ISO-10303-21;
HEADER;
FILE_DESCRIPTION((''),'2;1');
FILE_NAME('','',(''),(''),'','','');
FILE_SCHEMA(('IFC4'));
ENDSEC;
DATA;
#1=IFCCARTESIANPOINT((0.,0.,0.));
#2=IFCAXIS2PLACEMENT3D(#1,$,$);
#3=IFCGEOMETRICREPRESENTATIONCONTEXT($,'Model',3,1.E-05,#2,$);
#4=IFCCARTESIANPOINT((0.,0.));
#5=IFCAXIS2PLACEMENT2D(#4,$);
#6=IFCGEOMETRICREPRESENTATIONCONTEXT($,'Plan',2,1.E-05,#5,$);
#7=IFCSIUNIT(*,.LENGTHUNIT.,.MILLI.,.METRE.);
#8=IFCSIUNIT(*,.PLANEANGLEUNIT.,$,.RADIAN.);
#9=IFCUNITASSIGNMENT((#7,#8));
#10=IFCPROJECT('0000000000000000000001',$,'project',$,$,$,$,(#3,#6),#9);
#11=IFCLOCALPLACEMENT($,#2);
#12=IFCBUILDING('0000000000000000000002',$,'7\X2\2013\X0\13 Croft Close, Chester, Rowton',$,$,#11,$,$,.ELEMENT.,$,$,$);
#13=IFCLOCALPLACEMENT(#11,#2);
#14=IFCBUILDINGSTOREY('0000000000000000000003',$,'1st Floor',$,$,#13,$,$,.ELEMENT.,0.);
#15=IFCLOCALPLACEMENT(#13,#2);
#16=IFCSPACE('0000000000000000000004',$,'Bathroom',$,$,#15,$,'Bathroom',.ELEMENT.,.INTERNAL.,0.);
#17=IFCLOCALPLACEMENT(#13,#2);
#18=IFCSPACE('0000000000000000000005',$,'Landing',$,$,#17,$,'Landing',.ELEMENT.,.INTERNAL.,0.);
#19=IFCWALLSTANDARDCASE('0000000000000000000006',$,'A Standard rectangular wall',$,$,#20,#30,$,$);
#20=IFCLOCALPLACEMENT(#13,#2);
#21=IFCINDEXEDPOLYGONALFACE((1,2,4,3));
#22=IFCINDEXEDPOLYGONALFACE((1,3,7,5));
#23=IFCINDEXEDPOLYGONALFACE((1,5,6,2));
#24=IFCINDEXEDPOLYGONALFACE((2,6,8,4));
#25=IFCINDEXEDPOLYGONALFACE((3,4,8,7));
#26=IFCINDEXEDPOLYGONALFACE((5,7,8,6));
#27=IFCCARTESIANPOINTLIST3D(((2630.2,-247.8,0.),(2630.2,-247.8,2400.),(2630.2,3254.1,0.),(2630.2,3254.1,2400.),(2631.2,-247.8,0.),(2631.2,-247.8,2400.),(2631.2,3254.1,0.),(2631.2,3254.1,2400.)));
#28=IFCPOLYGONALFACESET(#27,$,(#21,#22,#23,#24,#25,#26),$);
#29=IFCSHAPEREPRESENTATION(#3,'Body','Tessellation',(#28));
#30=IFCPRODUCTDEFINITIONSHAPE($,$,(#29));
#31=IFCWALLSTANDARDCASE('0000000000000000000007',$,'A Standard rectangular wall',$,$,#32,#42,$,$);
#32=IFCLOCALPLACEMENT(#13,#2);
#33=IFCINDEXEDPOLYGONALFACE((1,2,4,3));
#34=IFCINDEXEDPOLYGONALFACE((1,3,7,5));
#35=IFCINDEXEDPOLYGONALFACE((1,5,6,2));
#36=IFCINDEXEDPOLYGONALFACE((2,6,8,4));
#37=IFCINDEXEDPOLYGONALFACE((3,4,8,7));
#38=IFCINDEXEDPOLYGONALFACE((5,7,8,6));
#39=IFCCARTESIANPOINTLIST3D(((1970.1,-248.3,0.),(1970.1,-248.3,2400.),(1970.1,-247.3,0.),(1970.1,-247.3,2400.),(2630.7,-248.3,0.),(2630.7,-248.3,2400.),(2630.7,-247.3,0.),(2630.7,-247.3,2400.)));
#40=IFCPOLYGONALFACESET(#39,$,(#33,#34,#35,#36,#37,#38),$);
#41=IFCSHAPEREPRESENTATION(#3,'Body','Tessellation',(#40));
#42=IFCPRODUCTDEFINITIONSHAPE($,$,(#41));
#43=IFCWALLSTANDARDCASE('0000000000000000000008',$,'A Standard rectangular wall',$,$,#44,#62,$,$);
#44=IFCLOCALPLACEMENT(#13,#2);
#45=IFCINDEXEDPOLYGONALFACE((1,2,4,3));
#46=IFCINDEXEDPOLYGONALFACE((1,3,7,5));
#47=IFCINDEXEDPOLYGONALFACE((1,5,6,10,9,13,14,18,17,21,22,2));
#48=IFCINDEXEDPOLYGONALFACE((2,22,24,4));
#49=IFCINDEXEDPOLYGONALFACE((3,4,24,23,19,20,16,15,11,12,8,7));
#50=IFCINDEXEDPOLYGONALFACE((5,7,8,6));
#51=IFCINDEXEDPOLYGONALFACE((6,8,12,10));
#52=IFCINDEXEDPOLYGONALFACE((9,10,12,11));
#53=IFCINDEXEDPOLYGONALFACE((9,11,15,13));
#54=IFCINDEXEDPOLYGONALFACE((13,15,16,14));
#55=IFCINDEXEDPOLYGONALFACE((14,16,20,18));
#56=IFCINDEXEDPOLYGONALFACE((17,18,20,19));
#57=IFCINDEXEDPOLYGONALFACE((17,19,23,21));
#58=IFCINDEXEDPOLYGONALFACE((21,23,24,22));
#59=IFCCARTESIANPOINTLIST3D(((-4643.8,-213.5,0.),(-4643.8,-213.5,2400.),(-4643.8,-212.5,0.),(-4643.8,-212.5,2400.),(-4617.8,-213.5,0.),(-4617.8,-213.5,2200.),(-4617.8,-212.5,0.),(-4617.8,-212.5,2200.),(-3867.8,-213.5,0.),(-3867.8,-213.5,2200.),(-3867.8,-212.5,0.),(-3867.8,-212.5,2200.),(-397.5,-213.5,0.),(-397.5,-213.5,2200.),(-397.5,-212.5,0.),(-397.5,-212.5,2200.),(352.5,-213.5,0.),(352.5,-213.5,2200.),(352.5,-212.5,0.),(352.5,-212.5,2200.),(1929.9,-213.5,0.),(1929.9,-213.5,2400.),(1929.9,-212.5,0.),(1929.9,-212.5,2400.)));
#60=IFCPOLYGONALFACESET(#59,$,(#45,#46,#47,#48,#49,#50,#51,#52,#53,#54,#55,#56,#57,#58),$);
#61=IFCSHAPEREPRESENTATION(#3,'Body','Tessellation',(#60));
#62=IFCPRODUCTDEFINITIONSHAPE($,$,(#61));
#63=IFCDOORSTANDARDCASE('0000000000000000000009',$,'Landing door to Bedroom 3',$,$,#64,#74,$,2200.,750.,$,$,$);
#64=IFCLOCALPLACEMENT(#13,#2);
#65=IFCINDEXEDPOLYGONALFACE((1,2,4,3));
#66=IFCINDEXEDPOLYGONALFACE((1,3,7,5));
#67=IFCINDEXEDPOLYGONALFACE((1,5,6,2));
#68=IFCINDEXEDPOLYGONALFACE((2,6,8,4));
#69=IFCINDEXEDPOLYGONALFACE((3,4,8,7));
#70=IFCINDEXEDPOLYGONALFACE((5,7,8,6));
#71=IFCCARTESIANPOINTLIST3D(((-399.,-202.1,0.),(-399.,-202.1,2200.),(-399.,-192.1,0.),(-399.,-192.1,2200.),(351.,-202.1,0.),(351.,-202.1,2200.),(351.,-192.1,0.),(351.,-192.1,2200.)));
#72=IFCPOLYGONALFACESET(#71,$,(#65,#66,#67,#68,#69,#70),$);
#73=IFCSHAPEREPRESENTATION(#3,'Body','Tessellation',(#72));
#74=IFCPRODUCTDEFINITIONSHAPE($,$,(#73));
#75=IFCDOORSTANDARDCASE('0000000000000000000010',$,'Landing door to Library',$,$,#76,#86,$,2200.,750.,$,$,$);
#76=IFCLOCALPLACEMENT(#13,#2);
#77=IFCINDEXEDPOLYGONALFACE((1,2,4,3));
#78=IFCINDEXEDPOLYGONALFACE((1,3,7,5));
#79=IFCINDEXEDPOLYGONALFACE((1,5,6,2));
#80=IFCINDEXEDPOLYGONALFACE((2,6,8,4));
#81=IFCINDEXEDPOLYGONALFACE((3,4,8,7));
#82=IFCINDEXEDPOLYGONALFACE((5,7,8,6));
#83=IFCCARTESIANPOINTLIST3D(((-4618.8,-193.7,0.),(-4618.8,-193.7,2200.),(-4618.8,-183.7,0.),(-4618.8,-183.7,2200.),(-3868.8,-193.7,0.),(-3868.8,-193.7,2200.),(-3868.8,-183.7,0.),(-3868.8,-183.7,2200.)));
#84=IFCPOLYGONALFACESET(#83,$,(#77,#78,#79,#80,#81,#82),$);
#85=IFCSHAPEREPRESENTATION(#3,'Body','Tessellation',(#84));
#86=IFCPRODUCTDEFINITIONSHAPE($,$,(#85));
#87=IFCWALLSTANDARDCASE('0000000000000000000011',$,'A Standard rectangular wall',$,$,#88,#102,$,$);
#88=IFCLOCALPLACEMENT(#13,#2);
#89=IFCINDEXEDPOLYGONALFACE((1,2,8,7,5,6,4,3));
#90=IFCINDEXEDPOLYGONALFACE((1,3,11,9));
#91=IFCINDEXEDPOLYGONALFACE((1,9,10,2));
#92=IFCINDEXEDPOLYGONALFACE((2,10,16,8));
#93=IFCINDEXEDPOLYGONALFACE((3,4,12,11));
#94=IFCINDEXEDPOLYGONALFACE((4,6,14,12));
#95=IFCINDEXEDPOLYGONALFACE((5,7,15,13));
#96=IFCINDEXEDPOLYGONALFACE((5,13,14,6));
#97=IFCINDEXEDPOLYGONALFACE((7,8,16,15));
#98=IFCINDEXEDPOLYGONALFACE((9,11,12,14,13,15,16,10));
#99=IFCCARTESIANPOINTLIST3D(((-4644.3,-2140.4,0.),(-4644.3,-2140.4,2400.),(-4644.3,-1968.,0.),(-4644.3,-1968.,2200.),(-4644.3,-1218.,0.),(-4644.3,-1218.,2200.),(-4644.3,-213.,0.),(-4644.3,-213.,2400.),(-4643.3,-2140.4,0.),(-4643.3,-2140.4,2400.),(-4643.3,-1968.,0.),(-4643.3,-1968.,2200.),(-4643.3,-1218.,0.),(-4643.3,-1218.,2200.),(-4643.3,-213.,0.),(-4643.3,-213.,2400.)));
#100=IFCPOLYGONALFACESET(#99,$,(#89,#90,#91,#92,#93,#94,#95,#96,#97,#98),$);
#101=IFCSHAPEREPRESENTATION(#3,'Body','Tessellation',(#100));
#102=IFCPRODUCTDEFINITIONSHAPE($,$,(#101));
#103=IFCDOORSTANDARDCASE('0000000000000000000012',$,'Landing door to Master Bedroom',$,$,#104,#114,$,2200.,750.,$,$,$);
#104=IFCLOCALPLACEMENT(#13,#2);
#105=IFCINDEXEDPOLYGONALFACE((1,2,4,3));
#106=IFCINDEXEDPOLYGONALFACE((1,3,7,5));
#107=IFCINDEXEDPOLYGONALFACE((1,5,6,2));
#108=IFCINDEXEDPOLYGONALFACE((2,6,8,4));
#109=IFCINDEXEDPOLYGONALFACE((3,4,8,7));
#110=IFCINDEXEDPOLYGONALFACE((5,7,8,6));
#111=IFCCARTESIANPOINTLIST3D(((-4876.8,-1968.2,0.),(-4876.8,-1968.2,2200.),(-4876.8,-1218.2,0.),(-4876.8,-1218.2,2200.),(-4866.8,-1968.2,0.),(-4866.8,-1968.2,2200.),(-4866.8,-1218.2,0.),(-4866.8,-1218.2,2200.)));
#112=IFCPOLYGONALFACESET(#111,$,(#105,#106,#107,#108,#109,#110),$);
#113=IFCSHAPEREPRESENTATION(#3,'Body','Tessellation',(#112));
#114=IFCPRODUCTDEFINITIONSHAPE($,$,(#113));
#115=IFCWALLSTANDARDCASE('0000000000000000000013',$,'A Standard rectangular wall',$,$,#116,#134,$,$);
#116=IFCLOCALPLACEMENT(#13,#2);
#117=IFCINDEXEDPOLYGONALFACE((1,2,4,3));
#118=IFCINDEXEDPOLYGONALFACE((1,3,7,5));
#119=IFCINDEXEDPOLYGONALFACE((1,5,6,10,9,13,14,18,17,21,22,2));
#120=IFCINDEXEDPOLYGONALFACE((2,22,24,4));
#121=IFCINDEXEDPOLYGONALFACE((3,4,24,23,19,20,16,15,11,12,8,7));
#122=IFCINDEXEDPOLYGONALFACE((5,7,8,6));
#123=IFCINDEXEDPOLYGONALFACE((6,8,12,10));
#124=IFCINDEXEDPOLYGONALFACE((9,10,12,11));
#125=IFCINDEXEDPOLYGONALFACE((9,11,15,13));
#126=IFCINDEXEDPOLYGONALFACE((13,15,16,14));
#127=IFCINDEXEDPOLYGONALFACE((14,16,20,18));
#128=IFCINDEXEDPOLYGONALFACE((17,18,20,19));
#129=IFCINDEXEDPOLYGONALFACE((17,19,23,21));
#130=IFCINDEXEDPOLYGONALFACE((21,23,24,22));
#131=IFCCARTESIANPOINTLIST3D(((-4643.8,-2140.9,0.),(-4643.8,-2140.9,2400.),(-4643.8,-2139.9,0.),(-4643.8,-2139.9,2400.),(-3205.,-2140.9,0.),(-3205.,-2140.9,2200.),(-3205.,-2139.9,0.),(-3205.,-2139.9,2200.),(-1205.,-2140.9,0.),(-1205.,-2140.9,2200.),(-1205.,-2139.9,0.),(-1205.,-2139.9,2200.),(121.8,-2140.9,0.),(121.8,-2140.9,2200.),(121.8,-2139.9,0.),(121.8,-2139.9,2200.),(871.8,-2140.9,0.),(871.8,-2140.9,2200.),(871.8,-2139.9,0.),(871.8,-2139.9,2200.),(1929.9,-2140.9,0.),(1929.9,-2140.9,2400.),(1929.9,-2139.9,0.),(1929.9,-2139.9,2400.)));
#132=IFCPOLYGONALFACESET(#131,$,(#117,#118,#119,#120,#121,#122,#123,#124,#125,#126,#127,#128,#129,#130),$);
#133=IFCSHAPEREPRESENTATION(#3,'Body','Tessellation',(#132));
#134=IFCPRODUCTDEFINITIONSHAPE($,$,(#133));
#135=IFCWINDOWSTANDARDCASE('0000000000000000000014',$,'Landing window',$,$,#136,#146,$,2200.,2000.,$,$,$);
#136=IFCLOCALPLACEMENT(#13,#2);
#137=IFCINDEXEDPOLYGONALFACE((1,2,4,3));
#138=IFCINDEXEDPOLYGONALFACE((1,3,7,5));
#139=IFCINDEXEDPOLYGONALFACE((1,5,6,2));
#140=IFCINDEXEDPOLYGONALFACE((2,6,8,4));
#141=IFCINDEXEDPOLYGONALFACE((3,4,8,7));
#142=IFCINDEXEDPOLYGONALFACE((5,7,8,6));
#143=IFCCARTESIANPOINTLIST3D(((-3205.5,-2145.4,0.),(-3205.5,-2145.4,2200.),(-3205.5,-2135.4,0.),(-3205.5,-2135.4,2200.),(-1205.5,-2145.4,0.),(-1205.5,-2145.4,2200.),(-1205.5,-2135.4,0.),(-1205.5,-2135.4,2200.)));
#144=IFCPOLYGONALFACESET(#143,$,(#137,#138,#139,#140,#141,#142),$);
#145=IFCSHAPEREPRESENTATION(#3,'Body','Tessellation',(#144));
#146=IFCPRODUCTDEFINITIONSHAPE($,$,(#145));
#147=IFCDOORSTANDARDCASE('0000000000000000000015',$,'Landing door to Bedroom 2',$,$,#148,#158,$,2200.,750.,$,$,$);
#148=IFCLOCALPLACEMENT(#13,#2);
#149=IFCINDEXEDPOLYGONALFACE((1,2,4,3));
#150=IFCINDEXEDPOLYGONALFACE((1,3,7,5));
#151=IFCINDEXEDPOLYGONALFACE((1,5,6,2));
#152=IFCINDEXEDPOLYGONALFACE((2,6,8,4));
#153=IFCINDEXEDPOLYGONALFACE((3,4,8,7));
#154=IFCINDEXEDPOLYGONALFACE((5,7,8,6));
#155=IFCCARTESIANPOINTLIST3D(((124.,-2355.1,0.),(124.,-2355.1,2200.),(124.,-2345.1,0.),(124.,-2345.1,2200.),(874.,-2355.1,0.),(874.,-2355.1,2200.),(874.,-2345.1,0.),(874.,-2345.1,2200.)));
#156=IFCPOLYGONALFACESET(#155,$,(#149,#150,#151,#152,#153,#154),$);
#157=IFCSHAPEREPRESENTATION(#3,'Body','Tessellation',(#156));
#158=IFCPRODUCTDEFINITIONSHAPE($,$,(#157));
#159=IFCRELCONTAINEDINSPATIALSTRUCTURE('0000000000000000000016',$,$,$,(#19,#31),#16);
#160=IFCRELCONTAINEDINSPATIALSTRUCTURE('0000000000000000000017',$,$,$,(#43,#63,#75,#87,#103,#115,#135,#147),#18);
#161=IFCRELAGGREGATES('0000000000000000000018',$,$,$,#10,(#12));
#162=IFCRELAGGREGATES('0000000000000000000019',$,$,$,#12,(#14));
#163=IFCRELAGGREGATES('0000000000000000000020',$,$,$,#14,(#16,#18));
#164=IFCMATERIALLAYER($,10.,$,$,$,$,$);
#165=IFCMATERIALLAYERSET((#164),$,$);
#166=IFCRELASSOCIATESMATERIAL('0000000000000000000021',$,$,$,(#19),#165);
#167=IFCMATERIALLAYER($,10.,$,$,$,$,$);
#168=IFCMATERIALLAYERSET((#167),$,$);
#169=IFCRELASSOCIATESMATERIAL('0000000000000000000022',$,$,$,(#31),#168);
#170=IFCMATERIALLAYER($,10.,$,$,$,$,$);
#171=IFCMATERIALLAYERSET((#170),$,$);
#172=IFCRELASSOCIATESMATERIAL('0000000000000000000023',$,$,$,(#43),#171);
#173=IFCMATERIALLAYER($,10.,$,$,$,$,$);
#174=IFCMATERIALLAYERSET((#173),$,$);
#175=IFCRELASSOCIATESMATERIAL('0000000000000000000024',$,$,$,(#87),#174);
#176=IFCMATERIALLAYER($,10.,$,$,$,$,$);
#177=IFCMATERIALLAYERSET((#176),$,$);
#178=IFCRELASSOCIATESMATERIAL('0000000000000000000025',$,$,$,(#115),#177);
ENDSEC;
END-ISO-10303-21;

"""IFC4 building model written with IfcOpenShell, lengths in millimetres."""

from ifc_helpers import new_model, si_unit, frame, origin, origin_2d, place, context, project, spatial, rectangle, extrude, layer, layer_set, layer_usage, element, fill, save


model = new_model("IFC4")

# Units and contexts
model_context = context("Model", 3, precision=1e-05, world=origin())
plan_context = context("Plan", 2, precision=1e-05, world=origin_2d())
ifc_project = project(units=[si_unit("LENGTHUNIT", "METRE", prefix="MILLI"), si_unit("PLANEANGLEUNIT", "RADIAN")], contexts=[model_context, plan_context])

# Building, storey, space
building_placement = place(None, origin())
building = spatial("IfcBuilding", under=ifc_project, at=building_placement, Name="7–13 Croft Close, Chester, Rowton", CompositionType="ELEMENT")
storey_placement = place(building_placement, origin())
storey = spatial("IfcBuildingStorey", under=building, at=storey_placement, Name="1st Floor", CompositionType="ELEMENT", Elevation=0.0)
space_1_placement = place(storey_placement, origin())
space_1 = spatial("IfcSpace", under=storey, at=space_1_placement, Name="Bathroom", LongName="Bathroom", CompositionType="ELEMENT", PredefinedType="INTERNAL", ElevationWithFlooring=0.0)

# Shared definitions
space_2_placement = place(storey_placement, origin())
space_2 = spatial("IfcSpace", under=storey, at=space_2_placement, Name="Landing", LongName="Landing", CompositionType="ELEMENT", PredefinedType="INTERNAL", ElevationWithFlooring=0.0)

# Walls
ifc_layer_1 = layer(None, 10.0)
ifc_layer_set_1 = layer_set([ifc_layer_1])
ifc_layer_usage_1 = layer_usage(ifc_layer_set_1, "AXIS2", "NEGATIVE", 150.0)
wall_1_placement = place(storey_placement, origin())
element("IfcWallStandardCase", 1, at=wall_1_placement, inside=space_1, material=ifc_layer_usage_1, Name="A Standard rectangular wall", context=model_context, shape_type="SweptSolid", body=[
    extrude(rectangle(XDim=1.0, YDim=3501.9, at=origin_2d()), frame((2630.7, 1503.2, 0.0), x_axis=(1.0, 0.0, 0.0)), (0.0, 0.0, 1.0), 2400.0),
])
ifc_layer_2 = layer(None, 10.0)
ifc_layer_set_2 = layer_set([ifc_layer_2])
ifc_layer_usage_2 = layer_usage(ifc_layer_set_2, "AXIS2", "NEGATIVE", 150.0)
wall_2_placement = place(storey_placement, origin())
element("IfcWallStandardCase", 2, at=wall_2_placement, inside=space_1, material=ifc_layer_usage_2, Name="A Standard rectangular wall", context=model_context, shape_type="SweptSolid", body=[
    extrude(rectangle(XDim=1.0, YDim=660.6, at=origin_2d()), frame((2300.4, -247.8, 0.0), x_axis=(0.0, -1.0, 0.0)), (0.0, 0.0, 1.0), 2400.0),
])

# Wall, openings, doors
ifc_layer_3 = layer(None, 10.0)
ifc_layer_set_3 = layer_set([ifc_layer_3])
ifc_layer_usage_3 = layer_usage(ifc_layer_set_3, "AXIS2", "NEGATIVE", 150.0)
wall_3_placement = place(storey_placement, origin())
wall_3 = element("IfcWallStandardCase", 3, at=wall_3_placement, inside=space_2, material=ifc_layer_usage_3, Name="A Standard rectangular wall", context=model_context, shape_type="SweptSolid", body=[
    extrude(rectangle(XDim=1.0, YDim=6573.7, at=origin_2d()), frame((-1356.9, -213.0, 0.0), x_axis=(0.0, -1.0, 0.0)), (0.0, 0.0, 1.0), 2400.0),
])
opening_1_placement = place(storey_placement, origin())
opening_1 = element("IfcOpeningElement", 4, at=opening_1_placement, cuts=wall_3, context=model_context, shape_type="SweptSolid", body=[
    extrude(rectangle(XDim=10.0, YDim=750.0, at=origin_2d()), frame((-22.5, -213.0, 0.0), x_axis=(0.0, -1.0, 0.0)), (0.0, 0.0, 1.0), 2200.0),
])
opening_2_placement = place(storey_placement, origin())
opening_2 = element("IfcOpeningElement", 5, at=opening_2_placement, cuts=wall_3, context=model_context, shape_type="SweptSolid", body=[
    extrude(rectangle(XDim=10.0, YDim=750.0, at=origin_2d()), frame((-4242.8, -213.0, 0.0), x_axis=(0.0, -1.0, 0.0)), (0.0, 0.0, 1.0), 2200.0),
])
door_1_placement = place(storey_placement, frame((-1.5, 15.9, 0.0)))
door_1 = element("IfcDoorStandardCase", 6, at=door_1_placement, inside=space_2, Name="Landing door to Bedroom 3", OverallHeight=2200.0, OverallWidth=750.0, context=model_context, shape_type="SweptSolid", body=[
    extrude(rectangle(XDim=10.0, YDim=750.0, at=origin_2d()), frame((-22.5, -213.0, 0.0), x_axis=(0.0, -1.0, 0.0)), (0.0, 0.0, 1.0), 2200.0),
])
fill(opening_1, door_1)
door_2_placement = place(storey_placement, frame((-1.0, 24.3, 0.0)))
door_2 = element("IfcDoorStandardCase", 7, at=door_2_placement, inside=space_2, Name="Landing door to Library", OverallHeight=2200.0, OverallWidth=750.0, context=model_context, shape_type="SweptSolid", body=[
    extrude(rectangle(XDim=10.0, YDim=750.0, at=origin_2d()), frame((-4242.8, -213.0, 0.0), x_axis=(0.0, -1.0, 0.0)), (0.0, 0.0, 1.0), 2200.0),
])
fill(opening_2, door_2)

# Wall, opening, door
ifc_layer_4 = layer(None, 10.0)
ifc_layer_set_4 = layer_set([ifc_layer_4])
ifc_layer_usage_4 = layer_usage(ifc_layer_set_4, "AXIS2", "NEGATIVE", 150.0)
wall_4_placement = place(storey_placement, origin())
wall_4 = element("IfcWallStandardCase", 8, at=wall_4_placement, inside=space_2, material=ifc_layer_usage_4, Name="A Standard rectangular wall", context=model_context, shape_type="SweptSolid", body=[
    extrude(rectangle(XDim=1.0, YDim=1927.4, at=origin_2d()), frame((-4643.8, -1176.7, 0.0), x_axis=(1.0, 0.0, 0.0)), (0.0, 0.0, 1.0), 2400.0),
])
opening_3_placement = place(storey_placement, origin())
opening_3 = element("IfcOpeningElement", 9, at=opening_3_placement, cuts=wall_4, context=model_context, shape_type="SweptSolid", body=[
    extrude(rectangle(XDim=10.0, YDim=750.0, at=origin_2d()), frame((-4643.8, -1593.0, 0.0), x_axis=(1.0, 0.0, 0.0)), (0.0, 0.0, 1.0), 2200.0),
])
door_3_placement = place(storey_placement, frame((-228.0, -0.2, 0.0)))
door_3 = element("IfcDoorStandardCase", 10, at=door_3_placement, inside=space_2, Name="Landing door to Master Bedroom", OverallHeight=2200.0, OverallWidth=750.0, context=model_context, shape_type="SweptSolid", body=[
    extrude(rectangle(XDim=10.0, YDim=750.0, at=origin_2d()), frame((-4643.8, -1593.0, 0.0), x_axis=(1.0, 0.0, 0.0)), (0.0, 0.0, 1.0), 2200.0),
])
fill(opening_3, door_3)

# Wall, openings, window, door
ifc_layer_5 = layer(None, 10.0)
ifc_layer_set_5 = layer_set([ifc_layer_5])
ifc_layer_usage_5 = layer_usage(ifc_layer_set_5, "AXIS2", "NEGATIVE", 150.0)
wall_5_placement = place(storey_placement, origin())
wall_5 = element("IfcWallStandardCase", 11, at=wall_5_placement, inside=space_2, material=ifc_layer_usage_5, Name="A Standard rectangular wall", context=model_context, shape_type="SweptSolid", body=[
    extrude(rectangle(XDim=1.0, YDim=6573.7, at=origin_2d()), frame((-1356.9, -2140.4, 0.0), x_axis=(0.0, 1.0, 0.0)), (0.0, 0.0, 1.0), 2400.0),
])
opening_4_placement = place(storey_placement, origin())
opening_4 = element("IfcOpeningElement", 12, at=opening_4_placement, cuts=wall_5, context=model_context, shape_type="SweptSolid", body=[
    extrude(rectangle(XDim=10.0, YDim=2000.0, at=origin_2d()), frame((-2205.0, -2140.4, 0.0), x_axis=(0.0, 1.0, 0.0)), (0.0, 0.0, 1.0), 2200.0),
])
opening_5_placement = place(storey_placement, origin())
opening_5 = element("IfcOpeningElement", 13, at=opening_5_placement, cuts=wall_5, context=model_context, shape_type="SweptSolid", body=[
    extrude(rectangle(XDim=10.0, YDim=750.0, at=origin_2d()), frame((496.8, -2140.4, 0.0), x_axis=(0.0, 1.0, 0.0)), (0.0, 0.0, 1.0), 2200.0),
])
window_1_placement = place(storey_placement, frame((-0.5, 0.0, 0.0)))
window_1 = element("IfcWindowStandardCase", 14, at=window_1_placement, inside=space_2, Name="Landing window", OverallHeight=2200.0, OverallWidth=2000.0, context=model_context, shape_type="SweptSolid", body=[
    extrude(rectangle(XDim=10.0, YDim=2000.0, at=origin_2d()), frame((-2205.0, -2140.4, 0.0), x_axis=(0.0, 1.0, 0.0)), (0.0, 0.0, 1.0), 2200.0),
])
fill(opening_4, window_1)
door_4_placement = place(storey_placement, frame((2.2, -209.7, 0.0)))
door_4 = element("IfcDoorStandardCase", 15, at=door_4_placement, inside=space_2, Name="Landing door to Bedroom 2", OverallHeight=2200.0, OverallWidth=750.0, context=model_context, shape_type="SweptSolid", body=[
    extrude(rectangle(XDim=10.0, YDim=750.0, at=origin_2d()), frame((496.8, -2140.4, 0.0), x_axis=(0.0, 1.0, 0.0)), (0.0, 0.0, 1.0), 2200.0),
])
fill(opening_5, door_4)

save(model, "model.ifc")
